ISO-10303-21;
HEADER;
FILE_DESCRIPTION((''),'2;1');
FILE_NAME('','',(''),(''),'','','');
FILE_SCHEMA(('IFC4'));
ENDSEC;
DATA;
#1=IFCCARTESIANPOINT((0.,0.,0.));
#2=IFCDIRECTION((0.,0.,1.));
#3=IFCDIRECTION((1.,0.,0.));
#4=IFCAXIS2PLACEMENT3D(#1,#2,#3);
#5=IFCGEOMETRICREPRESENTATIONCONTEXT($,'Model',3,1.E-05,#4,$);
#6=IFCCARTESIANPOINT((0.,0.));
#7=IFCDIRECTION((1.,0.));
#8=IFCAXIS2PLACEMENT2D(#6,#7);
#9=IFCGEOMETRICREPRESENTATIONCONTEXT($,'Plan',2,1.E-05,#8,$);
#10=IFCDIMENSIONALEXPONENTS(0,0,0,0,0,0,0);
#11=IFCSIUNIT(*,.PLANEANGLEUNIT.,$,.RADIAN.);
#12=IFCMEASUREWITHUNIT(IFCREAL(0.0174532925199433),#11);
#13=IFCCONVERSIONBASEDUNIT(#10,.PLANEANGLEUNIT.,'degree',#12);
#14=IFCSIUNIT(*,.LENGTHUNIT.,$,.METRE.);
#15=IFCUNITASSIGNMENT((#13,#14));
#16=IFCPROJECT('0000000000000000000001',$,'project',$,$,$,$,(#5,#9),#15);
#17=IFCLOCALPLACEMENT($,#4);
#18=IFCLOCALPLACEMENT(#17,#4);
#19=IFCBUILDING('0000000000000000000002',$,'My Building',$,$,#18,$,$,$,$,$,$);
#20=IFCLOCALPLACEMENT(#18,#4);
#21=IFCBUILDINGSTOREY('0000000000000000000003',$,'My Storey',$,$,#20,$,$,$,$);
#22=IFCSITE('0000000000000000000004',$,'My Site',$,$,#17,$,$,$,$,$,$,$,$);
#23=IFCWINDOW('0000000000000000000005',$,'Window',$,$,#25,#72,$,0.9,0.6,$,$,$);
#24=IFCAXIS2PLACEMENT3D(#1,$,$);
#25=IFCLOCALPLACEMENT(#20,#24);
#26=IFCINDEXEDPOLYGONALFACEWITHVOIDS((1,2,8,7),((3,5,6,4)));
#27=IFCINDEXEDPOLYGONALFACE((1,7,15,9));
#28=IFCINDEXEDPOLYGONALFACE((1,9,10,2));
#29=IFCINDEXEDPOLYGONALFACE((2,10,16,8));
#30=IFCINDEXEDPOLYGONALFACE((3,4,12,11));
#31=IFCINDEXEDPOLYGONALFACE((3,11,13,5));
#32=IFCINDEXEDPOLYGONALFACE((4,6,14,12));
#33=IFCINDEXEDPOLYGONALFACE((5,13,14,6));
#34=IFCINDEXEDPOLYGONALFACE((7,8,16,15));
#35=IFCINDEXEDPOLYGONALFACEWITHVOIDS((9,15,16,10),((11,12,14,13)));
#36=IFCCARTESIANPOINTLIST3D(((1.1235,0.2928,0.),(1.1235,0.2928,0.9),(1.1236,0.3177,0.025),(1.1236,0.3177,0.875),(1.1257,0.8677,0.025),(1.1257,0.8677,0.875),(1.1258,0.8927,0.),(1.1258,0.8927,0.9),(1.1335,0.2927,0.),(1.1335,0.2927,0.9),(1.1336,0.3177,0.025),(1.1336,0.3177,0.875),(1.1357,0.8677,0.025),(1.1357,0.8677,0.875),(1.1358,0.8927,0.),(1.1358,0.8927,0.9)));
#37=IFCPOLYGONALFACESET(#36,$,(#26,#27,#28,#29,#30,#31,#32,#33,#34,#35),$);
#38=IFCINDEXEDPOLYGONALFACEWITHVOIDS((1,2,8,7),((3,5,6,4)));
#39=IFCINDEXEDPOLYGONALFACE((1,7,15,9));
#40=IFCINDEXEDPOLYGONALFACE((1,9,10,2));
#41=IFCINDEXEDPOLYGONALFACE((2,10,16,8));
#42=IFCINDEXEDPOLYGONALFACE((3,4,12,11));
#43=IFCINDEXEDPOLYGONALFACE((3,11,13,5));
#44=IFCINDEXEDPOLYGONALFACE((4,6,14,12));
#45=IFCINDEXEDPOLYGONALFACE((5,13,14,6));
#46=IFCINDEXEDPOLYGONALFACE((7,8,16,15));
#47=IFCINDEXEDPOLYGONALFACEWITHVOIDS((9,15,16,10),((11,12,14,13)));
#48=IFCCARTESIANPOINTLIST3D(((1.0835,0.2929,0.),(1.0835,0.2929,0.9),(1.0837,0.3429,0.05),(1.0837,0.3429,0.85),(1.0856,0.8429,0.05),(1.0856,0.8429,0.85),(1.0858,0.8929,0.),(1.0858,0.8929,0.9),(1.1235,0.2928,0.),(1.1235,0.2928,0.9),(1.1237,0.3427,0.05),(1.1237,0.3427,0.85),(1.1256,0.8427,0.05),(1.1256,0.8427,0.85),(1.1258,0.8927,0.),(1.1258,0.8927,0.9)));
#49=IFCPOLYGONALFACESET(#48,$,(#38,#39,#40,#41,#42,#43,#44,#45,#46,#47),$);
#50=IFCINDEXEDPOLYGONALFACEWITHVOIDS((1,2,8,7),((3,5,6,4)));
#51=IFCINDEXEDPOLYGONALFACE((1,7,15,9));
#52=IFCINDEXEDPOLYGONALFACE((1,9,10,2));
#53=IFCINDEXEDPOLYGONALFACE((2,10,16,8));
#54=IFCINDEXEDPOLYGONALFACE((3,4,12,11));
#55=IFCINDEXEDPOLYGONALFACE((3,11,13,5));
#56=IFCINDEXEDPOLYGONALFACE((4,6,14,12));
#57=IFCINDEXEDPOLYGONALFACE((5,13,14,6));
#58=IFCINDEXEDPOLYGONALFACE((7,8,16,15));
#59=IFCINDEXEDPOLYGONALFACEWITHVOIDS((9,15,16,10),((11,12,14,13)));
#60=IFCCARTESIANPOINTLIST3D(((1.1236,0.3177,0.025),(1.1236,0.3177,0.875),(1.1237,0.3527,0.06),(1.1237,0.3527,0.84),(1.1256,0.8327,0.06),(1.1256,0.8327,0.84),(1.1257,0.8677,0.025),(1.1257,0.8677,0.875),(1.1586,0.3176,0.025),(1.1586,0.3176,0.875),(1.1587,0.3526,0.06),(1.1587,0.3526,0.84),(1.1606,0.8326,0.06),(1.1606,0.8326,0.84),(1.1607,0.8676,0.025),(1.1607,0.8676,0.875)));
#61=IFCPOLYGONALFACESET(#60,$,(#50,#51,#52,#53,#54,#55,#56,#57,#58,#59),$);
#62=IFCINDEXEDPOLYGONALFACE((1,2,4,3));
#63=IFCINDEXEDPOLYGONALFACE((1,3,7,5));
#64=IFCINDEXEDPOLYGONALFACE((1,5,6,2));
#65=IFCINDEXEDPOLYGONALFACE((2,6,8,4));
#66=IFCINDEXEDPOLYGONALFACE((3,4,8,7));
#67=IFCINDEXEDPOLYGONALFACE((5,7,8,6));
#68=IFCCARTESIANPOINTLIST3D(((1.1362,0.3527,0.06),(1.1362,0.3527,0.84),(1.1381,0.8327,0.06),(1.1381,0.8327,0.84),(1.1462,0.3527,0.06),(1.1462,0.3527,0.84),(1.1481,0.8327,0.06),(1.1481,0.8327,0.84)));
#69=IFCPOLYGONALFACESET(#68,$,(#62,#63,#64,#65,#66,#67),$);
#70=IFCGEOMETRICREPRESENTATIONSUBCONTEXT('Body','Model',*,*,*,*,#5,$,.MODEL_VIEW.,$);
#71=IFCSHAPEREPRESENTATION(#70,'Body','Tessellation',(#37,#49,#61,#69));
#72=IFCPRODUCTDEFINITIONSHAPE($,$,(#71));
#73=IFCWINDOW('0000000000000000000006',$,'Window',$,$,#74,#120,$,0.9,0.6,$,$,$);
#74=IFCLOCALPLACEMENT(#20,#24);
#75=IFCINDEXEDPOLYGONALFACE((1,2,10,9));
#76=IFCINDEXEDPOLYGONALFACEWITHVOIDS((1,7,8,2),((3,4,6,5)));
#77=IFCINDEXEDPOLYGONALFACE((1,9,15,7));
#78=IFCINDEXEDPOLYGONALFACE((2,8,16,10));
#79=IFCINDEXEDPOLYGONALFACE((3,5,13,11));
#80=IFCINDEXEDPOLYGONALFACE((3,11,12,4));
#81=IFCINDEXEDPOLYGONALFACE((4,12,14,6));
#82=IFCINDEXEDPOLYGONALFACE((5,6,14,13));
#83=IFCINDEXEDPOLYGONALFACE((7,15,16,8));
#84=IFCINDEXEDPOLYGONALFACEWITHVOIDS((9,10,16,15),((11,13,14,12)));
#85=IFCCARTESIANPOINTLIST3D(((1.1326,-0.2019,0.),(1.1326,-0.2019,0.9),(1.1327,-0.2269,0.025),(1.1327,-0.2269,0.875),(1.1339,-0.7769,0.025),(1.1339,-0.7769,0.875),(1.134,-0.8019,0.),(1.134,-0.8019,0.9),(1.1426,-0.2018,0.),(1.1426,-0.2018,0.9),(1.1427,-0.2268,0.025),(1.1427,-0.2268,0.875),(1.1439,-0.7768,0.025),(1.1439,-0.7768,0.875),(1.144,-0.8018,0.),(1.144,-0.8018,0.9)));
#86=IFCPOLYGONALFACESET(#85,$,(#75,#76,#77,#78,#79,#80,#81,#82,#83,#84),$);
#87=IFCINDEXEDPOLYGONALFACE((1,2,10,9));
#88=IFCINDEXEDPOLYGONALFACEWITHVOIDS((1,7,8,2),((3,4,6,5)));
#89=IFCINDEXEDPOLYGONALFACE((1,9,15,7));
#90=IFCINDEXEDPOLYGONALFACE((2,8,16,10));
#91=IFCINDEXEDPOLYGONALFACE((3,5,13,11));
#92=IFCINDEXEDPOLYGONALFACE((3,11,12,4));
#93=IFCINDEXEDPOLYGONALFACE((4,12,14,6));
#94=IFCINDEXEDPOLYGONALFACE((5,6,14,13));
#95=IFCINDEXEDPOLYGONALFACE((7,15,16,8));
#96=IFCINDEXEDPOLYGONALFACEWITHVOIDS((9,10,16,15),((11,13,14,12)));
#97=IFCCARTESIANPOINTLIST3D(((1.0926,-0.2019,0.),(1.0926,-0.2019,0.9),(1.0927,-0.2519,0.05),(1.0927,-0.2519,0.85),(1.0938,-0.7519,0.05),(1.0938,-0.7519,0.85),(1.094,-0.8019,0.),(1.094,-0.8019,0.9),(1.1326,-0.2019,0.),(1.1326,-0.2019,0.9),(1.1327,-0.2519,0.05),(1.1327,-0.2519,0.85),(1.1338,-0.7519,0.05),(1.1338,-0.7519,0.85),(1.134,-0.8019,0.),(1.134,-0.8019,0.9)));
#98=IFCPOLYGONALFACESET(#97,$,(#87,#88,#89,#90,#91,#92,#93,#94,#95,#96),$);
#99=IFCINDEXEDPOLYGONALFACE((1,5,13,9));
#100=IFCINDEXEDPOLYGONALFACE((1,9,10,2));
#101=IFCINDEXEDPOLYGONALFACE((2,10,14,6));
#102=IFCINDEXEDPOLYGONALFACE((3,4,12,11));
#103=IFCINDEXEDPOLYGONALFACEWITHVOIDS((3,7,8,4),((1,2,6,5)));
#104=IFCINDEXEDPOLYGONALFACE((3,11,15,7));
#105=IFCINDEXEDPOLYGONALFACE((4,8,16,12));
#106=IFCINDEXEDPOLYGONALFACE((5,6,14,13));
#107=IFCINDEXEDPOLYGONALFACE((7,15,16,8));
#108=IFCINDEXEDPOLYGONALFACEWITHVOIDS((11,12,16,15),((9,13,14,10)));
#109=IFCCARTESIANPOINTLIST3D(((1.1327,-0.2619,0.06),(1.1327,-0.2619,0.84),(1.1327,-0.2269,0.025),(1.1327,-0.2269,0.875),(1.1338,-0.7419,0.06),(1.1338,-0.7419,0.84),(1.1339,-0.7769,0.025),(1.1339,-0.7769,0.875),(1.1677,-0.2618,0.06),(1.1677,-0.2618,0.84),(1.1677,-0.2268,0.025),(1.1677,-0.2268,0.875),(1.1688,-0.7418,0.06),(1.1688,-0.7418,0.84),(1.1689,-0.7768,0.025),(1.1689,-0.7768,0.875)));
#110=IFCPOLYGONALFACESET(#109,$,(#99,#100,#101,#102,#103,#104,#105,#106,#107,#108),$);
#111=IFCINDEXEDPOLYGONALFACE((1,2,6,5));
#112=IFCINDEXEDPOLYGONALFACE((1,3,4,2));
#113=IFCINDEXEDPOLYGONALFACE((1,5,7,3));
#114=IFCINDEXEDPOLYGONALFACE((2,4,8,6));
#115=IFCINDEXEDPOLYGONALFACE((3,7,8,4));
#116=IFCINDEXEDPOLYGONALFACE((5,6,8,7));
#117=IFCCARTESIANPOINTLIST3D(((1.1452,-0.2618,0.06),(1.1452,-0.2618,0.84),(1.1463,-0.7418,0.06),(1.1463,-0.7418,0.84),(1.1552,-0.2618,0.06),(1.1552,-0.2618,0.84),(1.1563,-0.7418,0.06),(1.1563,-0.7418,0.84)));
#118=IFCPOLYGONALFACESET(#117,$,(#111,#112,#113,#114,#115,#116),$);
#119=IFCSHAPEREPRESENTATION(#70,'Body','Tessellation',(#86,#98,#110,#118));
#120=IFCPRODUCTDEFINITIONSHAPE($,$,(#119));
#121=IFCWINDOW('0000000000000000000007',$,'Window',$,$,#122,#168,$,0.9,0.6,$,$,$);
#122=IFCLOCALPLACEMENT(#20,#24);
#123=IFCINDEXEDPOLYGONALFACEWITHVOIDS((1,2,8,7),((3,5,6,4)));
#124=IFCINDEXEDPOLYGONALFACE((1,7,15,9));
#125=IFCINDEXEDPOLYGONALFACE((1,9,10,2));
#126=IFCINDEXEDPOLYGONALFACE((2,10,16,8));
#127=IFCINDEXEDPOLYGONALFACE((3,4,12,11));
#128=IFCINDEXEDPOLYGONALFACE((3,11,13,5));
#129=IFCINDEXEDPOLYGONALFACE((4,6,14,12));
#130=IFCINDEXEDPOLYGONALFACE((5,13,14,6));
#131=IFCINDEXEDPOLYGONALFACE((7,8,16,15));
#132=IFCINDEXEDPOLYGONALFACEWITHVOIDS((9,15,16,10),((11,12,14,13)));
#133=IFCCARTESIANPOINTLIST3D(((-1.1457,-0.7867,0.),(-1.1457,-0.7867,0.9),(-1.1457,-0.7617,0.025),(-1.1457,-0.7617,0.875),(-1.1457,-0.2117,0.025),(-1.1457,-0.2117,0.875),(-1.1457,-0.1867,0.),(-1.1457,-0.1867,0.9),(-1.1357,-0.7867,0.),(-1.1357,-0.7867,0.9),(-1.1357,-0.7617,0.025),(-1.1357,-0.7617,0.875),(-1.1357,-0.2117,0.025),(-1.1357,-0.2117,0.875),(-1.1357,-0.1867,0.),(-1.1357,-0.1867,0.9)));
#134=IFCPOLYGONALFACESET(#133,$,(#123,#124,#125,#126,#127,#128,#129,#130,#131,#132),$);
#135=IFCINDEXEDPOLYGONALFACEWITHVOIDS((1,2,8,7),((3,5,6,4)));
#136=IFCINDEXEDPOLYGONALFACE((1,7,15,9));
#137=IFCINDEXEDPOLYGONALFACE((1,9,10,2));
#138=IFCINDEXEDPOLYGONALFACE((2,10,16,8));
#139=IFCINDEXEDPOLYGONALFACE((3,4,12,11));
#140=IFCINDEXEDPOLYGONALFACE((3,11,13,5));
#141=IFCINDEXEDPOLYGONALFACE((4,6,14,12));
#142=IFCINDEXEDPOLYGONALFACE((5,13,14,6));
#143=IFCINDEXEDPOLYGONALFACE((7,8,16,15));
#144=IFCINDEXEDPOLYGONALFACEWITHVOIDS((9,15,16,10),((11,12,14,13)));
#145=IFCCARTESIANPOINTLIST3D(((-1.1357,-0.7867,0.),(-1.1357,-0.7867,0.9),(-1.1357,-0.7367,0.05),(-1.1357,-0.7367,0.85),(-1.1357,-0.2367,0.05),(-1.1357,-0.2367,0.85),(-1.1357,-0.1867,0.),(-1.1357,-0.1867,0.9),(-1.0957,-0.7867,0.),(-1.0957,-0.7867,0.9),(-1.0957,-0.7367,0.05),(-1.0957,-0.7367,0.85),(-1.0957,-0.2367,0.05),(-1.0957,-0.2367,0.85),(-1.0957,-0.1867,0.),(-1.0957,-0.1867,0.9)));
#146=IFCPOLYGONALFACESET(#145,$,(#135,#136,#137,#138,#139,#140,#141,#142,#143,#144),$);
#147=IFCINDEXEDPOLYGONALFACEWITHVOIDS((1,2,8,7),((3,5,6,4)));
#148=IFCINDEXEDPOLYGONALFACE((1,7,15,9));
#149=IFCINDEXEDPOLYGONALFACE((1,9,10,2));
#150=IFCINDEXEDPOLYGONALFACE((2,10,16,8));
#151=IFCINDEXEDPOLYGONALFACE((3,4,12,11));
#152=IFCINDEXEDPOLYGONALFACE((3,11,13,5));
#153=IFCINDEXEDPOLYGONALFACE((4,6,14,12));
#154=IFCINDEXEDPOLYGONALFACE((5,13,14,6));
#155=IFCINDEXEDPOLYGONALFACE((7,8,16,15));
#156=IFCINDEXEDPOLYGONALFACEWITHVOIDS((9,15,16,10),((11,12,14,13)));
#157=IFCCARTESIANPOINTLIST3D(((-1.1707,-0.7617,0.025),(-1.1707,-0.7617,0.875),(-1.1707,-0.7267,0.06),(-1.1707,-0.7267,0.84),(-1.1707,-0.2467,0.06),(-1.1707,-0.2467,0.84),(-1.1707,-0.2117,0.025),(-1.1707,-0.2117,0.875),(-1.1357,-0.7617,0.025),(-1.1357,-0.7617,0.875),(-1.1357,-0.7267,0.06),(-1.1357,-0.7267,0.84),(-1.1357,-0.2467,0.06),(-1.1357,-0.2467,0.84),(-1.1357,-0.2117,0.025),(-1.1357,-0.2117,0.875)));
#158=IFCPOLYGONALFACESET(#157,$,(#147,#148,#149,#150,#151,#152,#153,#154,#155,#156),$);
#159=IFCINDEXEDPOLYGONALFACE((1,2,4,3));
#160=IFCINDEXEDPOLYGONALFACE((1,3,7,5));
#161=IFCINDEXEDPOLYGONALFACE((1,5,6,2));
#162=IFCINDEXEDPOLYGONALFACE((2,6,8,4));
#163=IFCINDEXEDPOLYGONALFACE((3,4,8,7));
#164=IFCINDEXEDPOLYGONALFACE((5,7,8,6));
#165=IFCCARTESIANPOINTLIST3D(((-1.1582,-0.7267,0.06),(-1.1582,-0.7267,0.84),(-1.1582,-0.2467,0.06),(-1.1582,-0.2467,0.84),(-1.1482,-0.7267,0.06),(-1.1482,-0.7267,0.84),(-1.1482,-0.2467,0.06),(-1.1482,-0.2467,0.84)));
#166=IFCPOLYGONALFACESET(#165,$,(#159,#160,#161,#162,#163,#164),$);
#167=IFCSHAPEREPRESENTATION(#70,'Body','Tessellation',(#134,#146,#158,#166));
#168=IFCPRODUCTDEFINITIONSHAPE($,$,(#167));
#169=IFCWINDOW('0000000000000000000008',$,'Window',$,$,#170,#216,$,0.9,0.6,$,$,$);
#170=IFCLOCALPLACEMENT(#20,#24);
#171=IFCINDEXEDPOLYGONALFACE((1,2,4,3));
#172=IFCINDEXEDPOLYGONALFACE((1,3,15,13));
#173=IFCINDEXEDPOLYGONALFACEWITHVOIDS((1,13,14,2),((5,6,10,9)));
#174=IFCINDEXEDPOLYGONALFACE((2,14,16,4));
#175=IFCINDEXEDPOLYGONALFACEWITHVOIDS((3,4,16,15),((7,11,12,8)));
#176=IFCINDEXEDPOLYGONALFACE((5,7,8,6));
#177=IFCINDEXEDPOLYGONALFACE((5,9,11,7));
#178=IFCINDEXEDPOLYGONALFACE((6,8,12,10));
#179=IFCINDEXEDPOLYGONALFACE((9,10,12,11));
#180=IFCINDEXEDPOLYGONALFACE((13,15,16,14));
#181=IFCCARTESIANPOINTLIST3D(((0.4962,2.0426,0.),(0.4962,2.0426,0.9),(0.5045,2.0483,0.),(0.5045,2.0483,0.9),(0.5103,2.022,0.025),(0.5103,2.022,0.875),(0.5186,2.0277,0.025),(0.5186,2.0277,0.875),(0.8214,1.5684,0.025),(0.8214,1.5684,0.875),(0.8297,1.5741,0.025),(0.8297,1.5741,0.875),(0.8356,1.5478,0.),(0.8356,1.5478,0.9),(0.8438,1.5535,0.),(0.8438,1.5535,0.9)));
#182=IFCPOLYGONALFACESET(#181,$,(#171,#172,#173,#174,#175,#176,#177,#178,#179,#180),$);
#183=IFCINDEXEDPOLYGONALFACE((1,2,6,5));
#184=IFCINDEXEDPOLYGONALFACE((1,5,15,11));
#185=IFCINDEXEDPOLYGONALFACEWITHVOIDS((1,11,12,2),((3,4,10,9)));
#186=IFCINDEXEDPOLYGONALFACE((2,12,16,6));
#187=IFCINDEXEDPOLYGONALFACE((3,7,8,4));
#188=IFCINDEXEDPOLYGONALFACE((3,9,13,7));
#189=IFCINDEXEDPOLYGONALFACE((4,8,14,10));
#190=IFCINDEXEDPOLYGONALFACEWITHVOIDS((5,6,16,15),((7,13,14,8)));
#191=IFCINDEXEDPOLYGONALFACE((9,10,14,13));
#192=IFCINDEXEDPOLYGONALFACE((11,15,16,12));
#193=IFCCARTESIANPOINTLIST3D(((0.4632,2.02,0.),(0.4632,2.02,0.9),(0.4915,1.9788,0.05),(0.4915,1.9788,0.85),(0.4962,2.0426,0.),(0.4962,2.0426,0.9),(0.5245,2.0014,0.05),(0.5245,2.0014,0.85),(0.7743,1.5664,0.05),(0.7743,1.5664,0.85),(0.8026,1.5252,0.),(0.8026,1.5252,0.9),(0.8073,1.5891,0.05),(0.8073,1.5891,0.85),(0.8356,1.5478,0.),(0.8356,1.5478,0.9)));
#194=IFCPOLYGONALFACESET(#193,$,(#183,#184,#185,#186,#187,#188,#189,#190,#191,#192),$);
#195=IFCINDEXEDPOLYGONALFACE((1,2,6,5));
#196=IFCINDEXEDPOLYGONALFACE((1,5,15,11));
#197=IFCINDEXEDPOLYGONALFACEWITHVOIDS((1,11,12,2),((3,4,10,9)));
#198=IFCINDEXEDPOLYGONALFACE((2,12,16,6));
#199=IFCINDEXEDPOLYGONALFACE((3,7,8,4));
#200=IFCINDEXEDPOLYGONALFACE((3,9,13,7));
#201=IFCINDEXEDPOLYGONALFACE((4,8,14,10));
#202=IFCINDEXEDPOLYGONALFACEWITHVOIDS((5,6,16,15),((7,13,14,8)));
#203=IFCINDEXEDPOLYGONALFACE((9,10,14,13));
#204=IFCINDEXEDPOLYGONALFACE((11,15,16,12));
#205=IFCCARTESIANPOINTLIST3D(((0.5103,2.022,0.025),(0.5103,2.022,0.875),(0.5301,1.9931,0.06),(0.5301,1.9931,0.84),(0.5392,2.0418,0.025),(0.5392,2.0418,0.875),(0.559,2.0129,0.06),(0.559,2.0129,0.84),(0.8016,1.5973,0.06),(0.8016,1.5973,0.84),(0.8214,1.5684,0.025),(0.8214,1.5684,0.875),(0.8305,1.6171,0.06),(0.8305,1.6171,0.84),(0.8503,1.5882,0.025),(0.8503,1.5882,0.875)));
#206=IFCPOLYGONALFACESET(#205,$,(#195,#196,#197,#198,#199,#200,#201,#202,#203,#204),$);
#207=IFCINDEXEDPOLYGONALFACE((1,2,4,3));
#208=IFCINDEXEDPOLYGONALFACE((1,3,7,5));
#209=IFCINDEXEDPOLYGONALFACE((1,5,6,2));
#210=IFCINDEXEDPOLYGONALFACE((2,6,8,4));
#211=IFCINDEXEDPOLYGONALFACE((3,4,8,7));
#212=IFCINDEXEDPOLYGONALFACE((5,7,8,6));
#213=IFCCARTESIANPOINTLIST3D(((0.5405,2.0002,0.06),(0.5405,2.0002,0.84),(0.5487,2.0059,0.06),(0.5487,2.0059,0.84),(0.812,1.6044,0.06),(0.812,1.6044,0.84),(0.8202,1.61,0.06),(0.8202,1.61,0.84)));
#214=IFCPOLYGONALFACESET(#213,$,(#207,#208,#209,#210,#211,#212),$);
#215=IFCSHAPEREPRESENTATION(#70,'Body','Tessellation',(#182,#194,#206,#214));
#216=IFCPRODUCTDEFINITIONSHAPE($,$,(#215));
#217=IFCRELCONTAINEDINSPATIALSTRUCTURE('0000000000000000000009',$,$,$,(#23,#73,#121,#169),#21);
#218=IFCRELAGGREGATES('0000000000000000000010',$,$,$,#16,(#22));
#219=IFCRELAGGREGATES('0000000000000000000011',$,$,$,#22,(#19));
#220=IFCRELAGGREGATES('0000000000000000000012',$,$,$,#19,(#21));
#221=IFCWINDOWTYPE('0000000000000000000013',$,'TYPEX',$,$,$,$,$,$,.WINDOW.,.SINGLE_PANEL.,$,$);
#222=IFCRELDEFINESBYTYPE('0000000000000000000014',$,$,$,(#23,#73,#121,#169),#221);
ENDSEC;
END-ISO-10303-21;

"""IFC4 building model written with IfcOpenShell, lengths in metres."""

from ifc_helpers import new_model, entity, si_unit, converted_unit, frame, origin_with_axes, origin_2d_with_axis, place, context, subcontext, project, spatial, line, indexed_curve, outline, extrude, shape, source, transform, mapped, type_object, type_shapes, element, save


model = new_model("IFC4")

# Units and contexts
model_context = context("Model", 3, precision=1e-05, world=origin_with_axes())
plan_context = context("Plan", 2, precision=1e-05, world=origin_2d_with_axis())
body_context_1 = subcontext(model_context, "Body", "Model", "MODEL_VIEW")
body_context_2 = subcontext(plan_context, "Body", "Plan", "PLAN_VIEW")
ifc_project = project(units=[converted_unit("PLANEANGLEUNIT", "degree", entity("IfcReal", 0.0174532925199433), si_unit("PLANEANGLEUNIT", "RADIAN"), dimensions=[0, 0, 0, 0, 0, 0, 0]), si_unit("LENGTHUNIT", "METRE")], contexts=[model_context, plan_context])

# Site, building, storey
site_placement = place(None, origin_with_axes())
site = spatial("IfcSite", under=ifc_project, at=site_placement, Name="My Site")
building_placement = place(site_placement, origin_with_axes())
building = spatial("IfcBuilding", under=site, at=building_placement, Name="My Building")
storey_placement = place(building_placement, origin_with_axes())
storey = spatial("IfcBuildingStorey", under=building, at=storey_placement, Name="My Storey")

# Windows
window_type = type_object("IfcWindowType", Name="TYPEX", PartitioningType="SINGLE_PANEL", PredefinedType="WINDOW")
shared_shape_1 = source(origin_with_axes(), body_context_1, "Body", "SweptSolid", [
    extrude(outline(indexed_curve([(0.0, 0.0), (0.6, 0.0), (0.6, 0.9), (0.0, 0.9)], segments=[line(1, 2, 3, 4, 1)]), holes=[indexed_curve([(0.025, 0.025), (0.575, 0.025), (0.575, 0.875), (0.025, 0.875)], segments=[line(1, 2, 3, 4, 1)])]), frame((0.0, 0.09, 0.0), z_axis=(0.0, -1.0, 0.0), x_axis=(1.0, 0.0, 0.0)), (0.0, 0.0, -1.0), 0.01),
    extrude(outline(indexed_curve([(0.0, 0.0), (0.6, 0.0), (0.6, 0.9), (0.0, 0.9)], segments=[line(1, 2, 3, 4, 1)]), holes=[indexed_curve([(0.05, 0.05), (0.55, 0.05), (0.55, 0.85), (0.05, 0.85)], segments=[line(1, 2, 3, 4, 1)])]), frame((0.0, 0.05, 0.0), z_axis=(0.0, -1.0, 0.0), x_axis=(1.0, 0.0, 0.0)), (0.0, 0.0, -1.0), 0.04),
    extrude(outline(indexed_curve([(0.0, 0.0), (0.55, 0.0), (0.55, 0.85), (0.0, 0.85)], segments=[line(1, 2, 3, 4, 1)]), holes=[indexed_curve([(0.035, 0.035), (0.515, 0.035), (0.515, 0.815), (0.035, 0.815)], segments=[line(1, 2, 3, 4, 1)])]), frame((0.025, 0.09, 0.025), z_axis=(0.0, -1.0, 0.0), x_axis=(1.0, 0.0, 0.0)), (0.0, 0.0, -1.0), 0.035),
    extrude(outline(indexed_curve([(0.035, 0.035), (0.515, 0.035), (0.515, 0.815), (0.035, 0.815)], segments=[line(1, 2, 3, 4, 1)])), frame((0.025, 0.1025, 0.025), z_axis=(0.0, -1.0, 0.0), x_axis=(1.0, 0.0, 0.0)), (0.0, 0.0, -1.0), 0.01),
])
shared_shape_2 = source(origin_with_axes(), body_context_2, "Body", "Curve2D", [
    entity("IfcIndexedPolyCurve", entity("IfcCartesianPointList2D", [[0.05, 0.05], [0.55, 0.05]])),
    entity("IfcIndexedPolyCurve", entity("IfcCartesianPointList2D", [[0.0, 0.1], [0.025, 0.1], [0.025, 0.09], [0.05, 0.09], [0.05, 0.05], [0.0, 0.05]]), [entity("IfcLineIndex", [1, 2, 3, 4, 5, 6, 1])]),
    entity("IfcIndexedPolyCurve", entity("IfcCartesianPointList2D", [[0.6, 0.1], [0.575, 0.1], [0.575, 0.09], [0.55, 0.09], [0.55, 0.05], [0.6, 0.05]]), [entity("IfcLineIndex", [1, 2, 3, 4, 5, 6, 1])]),
    entity("IfcIndexedPolyCurve", entity("IfcCartesianPointList2D", [[0.025, 0.09], [0.06, 0.09], [0.06, 0.125], [0.025, 0.125]]), [entity("IfcLineIndex", [1, 2, 3, 4, 1])]),
    entity("IfcIndexedPolyCurve", entity("IfcCartesianPointList2D", [[0.575, 0.09], [0.54, 0.09], [0.54, 0.125], [0.575, 0.125]]), [entity("IfcLineIndex", [1, 2, 3, 4, 1])]),
    entity("IfcIndexedPolyCurve", entity("IfcCartesianPointList2D", [[0.06, 0.09], [0.54, 0.09]])),
    entity("IfcIndexedPolyCurve", entity("IfcCartesianPointList2D", [[0.06, 0.125], [0.54, 0.125]])),
    entity("IfcIndexedPolyCurve", entity("IfcCartesianPointList2D", [[0.06, 0.1075], [0.54, 0.1075]])),
])
type_shapes(window_type, [shared_shape_1, shared_shape_2])
for number, where, z_axis, x_axis, name in (
    (1, (1.0358, 0.8931, 0.0), (0.0, 0.0, 1.0), (-0.003853, -0.999993, 0.0), "Window"),
    (2, (1.0426, -0.2021, 0.0), (0.0, 0.0, 1.0), (0.002279, -0.999997, 0.0), "Window"),
    (3, (-1.0457, -0.7867, 0.0), (0.0, 0.0, 1.0), (-0.000029, 1.0, 0.0), "Window"),
    (4, (0.422, 1.9917, 0.0), (0.0, 0.0, 1.0), (0.565627, -0.824661, 0.0), "Window"),
):
    element("IfcWindow", number, at=place(storey_placement, frame(where, z_axis=z_axis, x_axis=x_axis)), inside=storey, type_object=window_type, Name=name, OverallHeight=0.9, OverallWidth=0.6, shapes=[
        shape(body_context_1, "Body", "MappedRepresentation", [mapped(shared_shape_1, transform((0.0, 0.0, 0.0), x_axis=(1.0, 0.0, 0.0), y_axis=(0.0, 1.0, 0.0), z_axis=(0.0, 0.0, 1.0), scale=1.0))]),
        shape(body_context_2, "Body", "MappedRepresentation", [mapped(shared_shape_2, transform((0.0, 0.0, 0.0), x_axis=(1.0, 0.0, 0.0), y_axis=(0.0, 1.0, 0.0), z_axis=(0.0, 0.0, 1.0), scale=1.0))]),
    ])

save(model, "model.ifc")
